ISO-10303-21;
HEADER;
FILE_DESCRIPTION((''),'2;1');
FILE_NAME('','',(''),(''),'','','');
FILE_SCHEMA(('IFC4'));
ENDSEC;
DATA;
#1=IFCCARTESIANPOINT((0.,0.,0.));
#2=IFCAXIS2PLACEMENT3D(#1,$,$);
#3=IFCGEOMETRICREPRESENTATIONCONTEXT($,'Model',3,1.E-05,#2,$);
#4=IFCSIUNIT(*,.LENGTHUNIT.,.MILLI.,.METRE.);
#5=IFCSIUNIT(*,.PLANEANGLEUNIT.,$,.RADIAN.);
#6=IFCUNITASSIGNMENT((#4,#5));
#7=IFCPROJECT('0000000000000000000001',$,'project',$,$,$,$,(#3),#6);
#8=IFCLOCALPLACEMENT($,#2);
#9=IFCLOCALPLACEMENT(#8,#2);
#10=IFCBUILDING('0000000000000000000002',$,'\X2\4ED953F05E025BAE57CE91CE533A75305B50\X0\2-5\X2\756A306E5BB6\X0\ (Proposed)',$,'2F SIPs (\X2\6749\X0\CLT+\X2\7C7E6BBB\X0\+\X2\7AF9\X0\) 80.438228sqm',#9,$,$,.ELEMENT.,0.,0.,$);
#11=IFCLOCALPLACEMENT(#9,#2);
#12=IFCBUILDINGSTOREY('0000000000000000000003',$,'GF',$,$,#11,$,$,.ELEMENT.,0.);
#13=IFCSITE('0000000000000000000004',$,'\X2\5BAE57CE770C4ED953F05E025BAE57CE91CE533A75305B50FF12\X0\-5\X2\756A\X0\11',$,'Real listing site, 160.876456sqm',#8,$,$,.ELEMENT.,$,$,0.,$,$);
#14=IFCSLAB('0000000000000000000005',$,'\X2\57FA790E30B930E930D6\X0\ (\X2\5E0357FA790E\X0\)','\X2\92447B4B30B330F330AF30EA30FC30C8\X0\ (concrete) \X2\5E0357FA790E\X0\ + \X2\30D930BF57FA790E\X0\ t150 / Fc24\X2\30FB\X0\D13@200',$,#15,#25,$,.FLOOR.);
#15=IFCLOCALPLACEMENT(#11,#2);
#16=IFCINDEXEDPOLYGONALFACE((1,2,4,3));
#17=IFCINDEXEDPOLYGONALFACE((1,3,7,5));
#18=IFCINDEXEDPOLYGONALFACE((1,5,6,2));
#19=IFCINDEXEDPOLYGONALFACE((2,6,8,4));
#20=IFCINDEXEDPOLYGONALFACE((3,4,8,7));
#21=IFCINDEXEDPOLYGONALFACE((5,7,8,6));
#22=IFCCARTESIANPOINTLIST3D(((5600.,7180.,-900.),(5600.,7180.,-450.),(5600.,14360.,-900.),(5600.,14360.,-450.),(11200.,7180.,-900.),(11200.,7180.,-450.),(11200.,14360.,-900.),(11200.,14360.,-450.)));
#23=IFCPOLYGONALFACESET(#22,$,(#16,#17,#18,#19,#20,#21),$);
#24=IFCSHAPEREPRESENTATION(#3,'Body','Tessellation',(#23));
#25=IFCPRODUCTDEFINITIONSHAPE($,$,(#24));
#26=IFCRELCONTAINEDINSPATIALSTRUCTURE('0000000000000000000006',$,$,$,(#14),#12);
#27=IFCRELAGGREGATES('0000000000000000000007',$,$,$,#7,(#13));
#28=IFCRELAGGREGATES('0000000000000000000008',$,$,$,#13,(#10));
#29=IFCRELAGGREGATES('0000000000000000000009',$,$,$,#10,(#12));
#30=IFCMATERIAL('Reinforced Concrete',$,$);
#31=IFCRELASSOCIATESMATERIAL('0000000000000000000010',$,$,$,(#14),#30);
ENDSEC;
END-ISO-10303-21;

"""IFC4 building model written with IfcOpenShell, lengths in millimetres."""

from ifc_helpers import new_model, si_unit, frame, frame_2d, origin, place, context, project, spatial, rectangle, extrude, material, element, save


model = new_model("IFC4")

# Units and contexts
model_context = context("Model", 3, precision=1e-05, world=origin())
ifc_project = project(units=[si_unit("LENGTHUNIT", "METRE", prefix="MILLI"), si_unit("PLANEANGLEUNIT", "RADIAN")], contexts=[model_context])

# Site, building, storey
site_placement = place(None, origin())
site = spatial("IfcSite", under=ifc_project, at=site_placement, Name="宮城県仙台市宮城野区田子２-5番11", ObjectType="Real listing site, 160.876456sqm", CompositionType="ELEMENT", RefElevation=0.0)
building_placement = place(site_placement, origin())
building = spatial("IfcBuilding", under=site, at=building_placement, Name="仙台市宮城野区田子2-5番の家 (Proposed)", ObjectType="2F SIPs (杉CLT+籾殻+竹) 80.438228sqm", CompositionType="ELEMENT", ElevationOfRefHeight=0.0, ElevationOfTerrain=0.0)
storey_placement = place(building_placement, origin())
storey = spatial("IfcBuildingStorey", under=building, at=storey_placement, Name="GF", CompositionType="ELEMENT", Elevation=0.0)

# Slab
ifc_material_1 = material(Name="Reinforced Concrete")
slab_1_placement = place(storey_placement, frame((2800.0, 3590.0, -450.0)))
element("IfcSlab", 1, at=slab_1_placement, inside=storey, material=ifc_material_1, Name="基礎スラブ (布基礎)", Description="鉄筋コンクリート (concrete) 布基礎 + ベタ基礎 t150 / Fc24・D13@200", PredefinedType="FLOOR", context=model_context, shape_type="SweptSolid", body=[
    extrude(rectangle(XDim=5600.0, YDim=7180.0, at=frame_2d((2800.0, 3590.0))), frame((2800.0, 3590.0, -450.0)), (0.0, 0.0, 1.0), 450.0),
])

save(model, "model.ifc")
